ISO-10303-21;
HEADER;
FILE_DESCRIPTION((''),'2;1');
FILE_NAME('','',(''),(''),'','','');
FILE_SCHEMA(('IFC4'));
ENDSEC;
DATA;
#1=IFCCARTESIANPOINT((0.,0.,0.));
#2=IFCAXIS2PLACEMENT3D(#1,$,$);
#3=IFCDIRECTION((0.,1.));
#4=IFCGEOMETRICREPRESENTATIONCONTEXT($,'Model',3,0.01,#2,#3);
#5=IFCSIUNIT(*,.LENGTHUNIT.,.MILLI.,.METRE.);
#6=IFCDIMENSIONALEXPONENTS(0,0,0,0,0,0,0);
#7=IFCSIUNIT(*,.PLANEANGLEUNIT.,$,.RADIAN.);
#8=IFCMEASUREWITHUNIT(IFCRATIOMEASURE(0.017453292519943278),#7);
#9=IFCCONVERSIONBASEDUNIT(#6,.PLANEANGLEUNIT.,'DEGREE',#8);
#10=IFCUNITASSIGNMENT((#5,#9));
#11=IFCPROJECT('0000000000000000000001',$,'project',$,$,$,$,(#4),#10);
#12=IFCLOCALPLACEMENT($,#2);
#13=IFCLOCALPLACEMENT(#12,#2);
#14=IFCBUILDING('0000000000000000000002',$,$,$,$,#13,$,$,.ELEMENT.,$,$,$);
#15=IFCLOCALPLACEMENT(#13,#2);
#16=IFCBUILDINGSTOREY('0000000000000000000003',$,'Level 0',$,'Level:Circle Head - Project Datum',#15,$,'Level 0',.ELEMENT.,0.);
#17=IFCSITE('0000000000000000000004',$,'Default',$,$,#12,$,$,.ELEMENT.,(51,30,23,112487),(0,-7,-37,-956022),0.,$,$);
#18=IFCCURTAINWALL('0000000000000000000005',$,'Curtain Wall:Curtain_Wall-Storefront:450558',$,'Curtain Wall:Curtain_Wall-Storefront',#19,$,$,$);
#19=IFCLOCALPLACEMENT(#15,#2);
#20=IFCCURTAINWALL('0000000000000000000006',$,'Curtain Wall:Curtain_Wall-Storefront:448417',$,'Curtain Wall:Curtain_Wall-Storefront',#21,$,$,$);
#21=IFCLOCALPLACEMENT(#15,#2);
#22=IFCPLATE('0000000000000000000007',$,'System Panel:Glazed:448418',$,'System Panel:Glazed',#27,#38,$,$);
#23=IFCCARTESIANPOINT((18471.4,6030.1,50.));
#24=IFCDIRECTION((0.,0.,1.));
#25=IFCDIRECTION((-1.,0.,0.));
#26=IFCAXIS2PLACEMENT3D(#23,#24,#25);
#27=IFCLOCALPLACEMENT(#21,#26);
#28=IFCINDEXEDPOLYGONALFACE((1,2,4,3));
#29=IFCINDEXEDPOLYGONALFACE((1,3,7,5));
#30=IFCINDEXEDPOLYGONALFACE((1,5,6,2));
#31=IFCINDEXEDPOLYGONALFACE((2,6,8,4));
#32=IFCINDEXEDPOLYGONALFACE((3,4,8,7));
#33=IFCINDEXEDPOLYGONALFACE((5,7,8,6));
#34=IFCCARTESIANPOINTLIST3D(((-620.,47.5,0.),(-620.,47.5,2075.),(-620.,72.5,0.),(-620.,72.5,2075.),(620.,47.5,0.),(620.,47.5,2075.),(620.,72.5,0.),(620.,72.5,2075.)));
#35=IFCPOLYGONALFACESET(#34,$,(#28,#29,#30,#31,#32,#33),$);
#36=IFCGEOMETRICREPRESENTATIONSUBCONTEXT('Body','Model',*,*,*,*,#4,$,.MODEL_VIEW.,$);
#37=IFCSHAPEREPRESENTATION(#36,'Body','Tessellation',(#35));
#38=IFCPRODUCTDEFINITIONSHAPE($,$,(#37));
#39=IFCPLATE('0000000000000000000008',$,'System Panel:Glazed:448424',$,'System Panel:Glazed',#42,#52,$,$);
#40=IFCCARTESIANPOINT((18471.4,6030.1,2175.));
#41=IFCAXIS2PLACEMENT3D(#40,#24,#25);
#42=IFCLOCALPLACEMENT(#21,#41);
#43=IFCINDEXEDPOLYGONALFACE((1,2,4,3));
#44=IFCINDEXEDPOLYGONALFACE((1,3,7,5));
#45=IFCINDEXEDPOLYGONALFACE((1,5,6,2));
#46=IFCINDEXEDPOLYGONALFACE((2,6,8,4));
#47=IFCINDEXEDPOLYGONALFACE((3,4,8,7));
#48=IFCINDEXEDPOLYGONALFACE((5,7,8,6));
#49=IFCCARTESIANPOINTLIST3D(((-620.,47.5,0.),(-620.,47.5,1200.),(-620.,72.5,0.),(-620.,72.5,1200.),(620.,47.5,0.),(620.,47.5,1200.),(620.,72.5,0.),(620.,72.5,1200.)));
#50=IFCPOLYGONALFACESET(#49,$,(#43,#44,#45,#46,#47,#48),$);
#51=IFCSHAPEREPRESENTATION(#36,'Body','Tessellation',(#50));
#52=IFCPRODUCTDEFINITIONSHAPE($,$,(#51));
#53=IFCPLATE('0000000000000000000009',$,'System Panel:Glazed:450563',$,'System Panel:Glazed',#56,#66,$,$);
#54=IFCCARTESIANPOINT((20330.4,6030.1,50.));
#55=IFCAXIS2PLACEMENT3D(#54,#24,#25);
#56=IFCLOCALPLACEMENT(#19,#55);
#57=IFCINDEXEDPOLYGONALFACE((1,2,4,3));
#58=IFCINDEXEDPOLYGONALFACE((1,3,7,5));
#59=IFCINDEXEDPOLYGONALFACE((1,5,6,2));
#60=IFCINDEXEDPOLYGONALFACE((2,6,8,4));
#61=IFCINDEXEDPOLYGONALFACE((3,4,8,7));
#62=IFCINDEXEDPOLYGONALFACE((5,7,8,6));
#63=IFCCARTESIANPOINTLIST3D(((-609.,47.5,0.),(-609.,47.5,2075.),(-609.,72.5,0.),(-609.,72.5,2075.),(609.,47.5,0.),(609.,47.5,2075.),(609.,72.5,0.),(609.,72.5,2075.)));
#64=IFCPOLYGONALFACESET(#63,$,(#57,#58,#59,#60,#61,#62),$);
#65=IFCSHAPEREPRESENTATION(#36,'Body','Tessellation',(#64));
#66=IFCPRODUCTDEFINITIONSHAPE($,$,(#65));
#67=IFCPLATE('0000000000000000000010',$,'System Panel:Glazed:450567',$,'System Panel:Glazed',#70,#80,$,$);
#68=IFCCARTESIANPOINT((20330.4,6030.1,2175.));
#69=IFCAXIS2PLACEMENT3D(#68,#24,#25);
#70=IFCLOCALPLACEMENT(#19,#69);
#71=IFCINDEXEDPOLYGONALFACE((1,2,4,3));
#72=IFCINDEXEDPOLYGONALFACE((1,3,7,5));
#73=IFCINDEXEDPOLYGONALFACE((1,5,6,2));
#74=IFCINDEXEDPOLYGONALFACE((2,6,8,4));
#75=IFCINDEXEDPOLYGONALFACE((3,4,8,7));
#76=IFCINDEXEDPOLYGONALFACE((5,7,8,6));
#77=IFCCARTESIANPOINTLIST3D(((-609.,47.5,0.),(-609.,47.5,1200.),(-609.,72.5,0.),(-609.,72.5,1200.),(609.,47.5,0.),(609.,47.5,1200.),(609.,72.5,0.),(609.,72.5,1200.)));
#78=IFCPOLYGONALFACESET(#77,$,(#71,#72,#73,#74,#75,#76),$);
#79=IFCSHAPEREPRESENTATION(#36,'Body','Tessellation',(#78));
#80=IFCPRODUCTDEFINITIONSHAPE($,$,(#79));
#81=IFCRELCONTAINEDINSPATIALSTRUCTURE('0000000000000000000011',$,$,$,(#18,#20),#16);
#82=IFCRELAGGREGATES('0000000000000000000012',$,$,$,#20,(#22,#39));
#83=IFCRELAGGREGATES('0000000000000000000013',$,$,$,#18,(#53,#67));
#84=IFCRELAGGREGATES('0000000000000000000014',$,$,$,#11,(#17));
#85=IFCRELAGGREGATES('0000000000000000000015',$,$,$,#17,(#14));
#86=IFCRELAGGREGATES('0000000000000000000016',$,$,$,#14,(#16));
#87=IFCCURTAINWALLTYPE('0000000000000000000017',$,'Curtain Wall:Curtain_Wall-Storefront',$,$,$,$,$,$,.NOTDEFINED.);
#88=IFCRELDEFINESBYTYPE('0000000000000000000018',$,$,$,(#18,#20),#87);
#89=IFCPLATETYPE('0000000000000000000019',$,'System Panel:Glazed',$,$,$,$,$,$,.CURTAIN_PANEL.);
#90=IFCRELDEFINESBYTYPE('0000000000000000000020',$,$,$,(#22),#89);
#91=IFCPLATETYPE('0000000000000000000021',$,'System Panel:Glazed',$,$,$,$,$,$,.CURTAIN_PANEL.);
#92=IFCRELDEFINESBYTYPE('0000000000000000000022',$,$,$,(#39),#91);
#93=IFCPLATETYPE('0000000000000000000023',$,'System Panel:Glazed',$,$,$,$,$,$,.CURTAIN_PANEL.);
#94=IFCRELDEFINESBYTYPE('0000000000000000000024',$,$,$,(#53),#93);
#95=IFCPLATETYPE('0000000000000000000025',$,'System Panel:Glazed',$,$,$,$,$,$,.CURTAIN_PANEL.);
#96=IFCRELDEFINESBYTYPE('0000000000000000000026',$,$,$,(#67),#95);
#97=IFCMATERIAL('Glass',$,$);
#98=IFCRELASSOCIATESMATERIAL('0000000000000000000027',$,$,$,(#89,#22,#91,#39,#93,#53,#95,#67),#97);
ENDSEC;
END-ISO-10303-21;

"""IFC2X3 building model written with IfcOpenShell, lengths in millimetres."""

from ifc_helpers import new_model, entity, si_unit, converted_unit, direction, frame, origin, origin_2d_with_axis, place, context, subcontext, project, spatial, rectangle, extrude, source, transform, mapped, material, type_object, type_shapes, element, aggregate, save


model = new_model("IFC2X3")

# Units and contexts
model_context = context("Model", 3, precision=0.01, world=origin(), true_north=direction((0.0, 1.0)))
body_context = subcontext(model_context, "Body", "Model", "MODEL_VIEW")
ifc_project = project(units=[si_unit("LENGTHUNIT", "METRE", prefix="MILLI"), converted_unit("PLANEANGLEUNIT", "DEGREE", entity("IfcRatioMeasure", 0.017453292519943278), si_unit("PLANEANGLEUNIT", "RADIAN"), dimensions=[0, 0, 0, 0, 0, 0, 0])], contexts=[model_context])

# Site, building, storey
site_placement = place(None, origin())
site = spatial("IfcSite", under=ifc_project, at=site_placement, Name="Default", CompositionType="ELEMENT", RefLatitude=(51, 30, 23, 112487), RefLongitude=(0, -7, -37, -956022), RefElevation=0.0)
building_placement = place(site_placement, origin())
building = spatial("IfcBuilding", under=site, at=building_placement, CompositionType="ELEMENT")
storey_placement = place(building_placement, origin())
storey = spatial("IfcBuildingStorey", under=building, at=storey_placement, Name="Level 0", ObjectType="Level:Circle Head - Project Datum", LongName="Level 0", CompositionType="ELEMENT", Elevation=0.0)

# Curtain walls
curtain_wall_type = type_object("IfcCurtainWallType", Name="Curtain Wall:Curtain_Wall-Storefront", PredefinedType="NOTDEFINED")
curtain_wall_1_placement = place(storey_placement, origin())
curtain_wall_1 = element("IfcCurtainWall", 1, at=curtain_wall_1_placement, inside=storey, type_object=curtain_wall_type, Name="Curtain Wall:Curtain_Wall-Storefront:450558", ObjectType="Curtain Wall:Curtain_Wall-Storefront")
curtain_wall_2_placement = place(storey_placement, origin())
curtain_wall_2 = element("IfcCurtainWall", 2, at=curtain_wall_2_placement, inside=storey, type_object=curtain_wall_type, Name="Curtain Wall:Curtain_Wall-Storefront:448417", ObjectType="Curtain Wall:Curtain_Wall-Storefront")

# Plates
ifc_material_1 = material(Name="Glass")
plate_type_1 = type_object("IfcPlateType", Name="System Panel:Glazed", PredefinedType="CURTAIN_PANEL", material=ifc_material_1)
shared_shape_1 = source(origin(), body_context, "Body", "SweptSolid", [
    extrude(rectangle(XDim=25.0, YDim=1240.0, at=origin_2d_with_axis()), frame((0.0, 60.0, 0.0), z_axis=(0.0, 0.0, 1.0), x_axis=(0.0, 1.0, 0.0)), (0.0, 0.0, 1.0), 2075.0),
])
type_shapes(plate_type_1, [shared_shape_1])
plate_1_placement = place(curtain_wall_2_placement, frame((18471.4, 6030.1, 50.0), z_axis=(0.0, 0.0, 1.0), x_axis=(-1.0, 0.0, 0.0)))
plate_1 = element("IfcPlate", 3, at=plate_1_placement, type_object=plate_type_1, material=ifc_material_1, Name="System Panel:Glazed:448418", ObjectType="System Panel:Glazed", context=body_context, shape_type="MappedRepresentation", body=[
    mapped(shared_shape_1, transform((0.0, 0.0, 0.0), scale=1.0)),
])
plate_type_2 = type_object("IfcPlateType", Name="System Panel:Glazed", PredefinedType="CURTAIN_PANEL", material=ifc_material_1)
shared_shape_2 = source(origin(), body_context, "Body", "SweptSolid", [
    extrude(rectangle(XDim=25.0, YDim=1240.0, at=origin_2d_with_axis()), frame((0.0, 60.0, 0.0), z_axis=(0.0, 0.0, 1.0), x_axis=(0.0, 1.0, 0.0)), (0.0, 0.0, 1.0), 1200.0),
])
type_shapes(plate_type_2, [shared_shape_2])
plate_2_placement = place(curtain_wall_2_placement, frame((18471.4, 6030.1, 2175.0), z_axis=(0.0, 0.0, 1.0), x_axis=(-1.0, 0.0, 0.0)))
plate_2 = element("IfcPlate", 4, at=plate_2_placement, type_object=plate_type_2, material=ifc_material_1, Name="System Panel:Glazed:448424", ObjectType="System Panel:Glazed", context=body_context, shape_type="MappedRepresentation", body=[
    mapped(shared_shape_2, transform((0.0, 0.0, 0.0), scale=1.0)),
])
aggregate(curtain_wall_2, [plate_1, plate_2])
plate_type_3 = type_object("IfcPlateType", Name="System Panel:Glazed", PredefinedType="CURTAIN_PANEL", material=ifc_material_1)
shared_shape_3 = source(origin(), body_context, "Body", "SweptSolid", [
    extrude(rectangle(XDim=25.0, YDim=1218.0, at=origin_2d_with_axis()), frame((0.0, 60.0, 0.0), z_axis=(0.0, 0.0, 1.0), x_axis=(0.0, 1.0, 0.0)), (0.0, 0.0, 1.0), 2075.0),
])
type_shapes(plate_type_3, [shared_shape_3])
plate_3_placement = place(curtain_wall_1_placement, frame((20330.4, 6030.1, 50.0), z_axis=(0.0, 0.0, 1.0), x_axis=(-1.0, 0.0, 0.0)))
plate_3 = element("IfcPlate", 5, at=plate_3_placement, type_object=plate_type_3, material=ifc_material_1, Name="System Panel:Glazed:450563", ObjectType="System Panel:Glazed", context=body_context, shape_type="MappedRepresentation", body=[
    mapped(shared_shape_3, transform((0.0, 0.0, 0.0), scale=1.0)),
])
plate_type_4 = type_object("IfcPlateType", Name="System Panel:Glazed", PredefinedType="CURTAIN_PANEL", material=ifc_material_1)
shared_shape_4 = source(origin(), body_context, "Body", "SweptSolid", [
    extrude(rectangle(XDim=25.0, YDim=1218.0, at=origin_2d_with_axis()), frame((0.0, 60.0, 0.0), z_axis=(0.0, 0.0, 1.0), x_axis=(0.0, 1.0, 0.0)), (0.0, 0.0, 1.0), 1200.0),
])
type_shapes(plate_type_4, [shared_shape_4])
plate_4_placement = place(curtain_wall_1_placement, frame((20330.4, 6030.1, 2175.0), z_axis=(0.0, 0.0, 1.0), x_axis=(-1.0, 0.0, 0.0)))
plate_4 = element("IfcPlate", 6, at=plate_4_placement, type_object=plate_type_4, material=ifc_material_1, Name="System Panel:Glazed:450567", ObjectType="System Panel:Glazed", context=body_context, shape_type="MappedRepresentation", body=[
    mapped(shared_shape_4, transform((0.0, 0.0, 0.0), scale=1.0)),
])
aggregate(curtain_wall_1, [plate_3, plate_4])

save(model, "model.ifc")
